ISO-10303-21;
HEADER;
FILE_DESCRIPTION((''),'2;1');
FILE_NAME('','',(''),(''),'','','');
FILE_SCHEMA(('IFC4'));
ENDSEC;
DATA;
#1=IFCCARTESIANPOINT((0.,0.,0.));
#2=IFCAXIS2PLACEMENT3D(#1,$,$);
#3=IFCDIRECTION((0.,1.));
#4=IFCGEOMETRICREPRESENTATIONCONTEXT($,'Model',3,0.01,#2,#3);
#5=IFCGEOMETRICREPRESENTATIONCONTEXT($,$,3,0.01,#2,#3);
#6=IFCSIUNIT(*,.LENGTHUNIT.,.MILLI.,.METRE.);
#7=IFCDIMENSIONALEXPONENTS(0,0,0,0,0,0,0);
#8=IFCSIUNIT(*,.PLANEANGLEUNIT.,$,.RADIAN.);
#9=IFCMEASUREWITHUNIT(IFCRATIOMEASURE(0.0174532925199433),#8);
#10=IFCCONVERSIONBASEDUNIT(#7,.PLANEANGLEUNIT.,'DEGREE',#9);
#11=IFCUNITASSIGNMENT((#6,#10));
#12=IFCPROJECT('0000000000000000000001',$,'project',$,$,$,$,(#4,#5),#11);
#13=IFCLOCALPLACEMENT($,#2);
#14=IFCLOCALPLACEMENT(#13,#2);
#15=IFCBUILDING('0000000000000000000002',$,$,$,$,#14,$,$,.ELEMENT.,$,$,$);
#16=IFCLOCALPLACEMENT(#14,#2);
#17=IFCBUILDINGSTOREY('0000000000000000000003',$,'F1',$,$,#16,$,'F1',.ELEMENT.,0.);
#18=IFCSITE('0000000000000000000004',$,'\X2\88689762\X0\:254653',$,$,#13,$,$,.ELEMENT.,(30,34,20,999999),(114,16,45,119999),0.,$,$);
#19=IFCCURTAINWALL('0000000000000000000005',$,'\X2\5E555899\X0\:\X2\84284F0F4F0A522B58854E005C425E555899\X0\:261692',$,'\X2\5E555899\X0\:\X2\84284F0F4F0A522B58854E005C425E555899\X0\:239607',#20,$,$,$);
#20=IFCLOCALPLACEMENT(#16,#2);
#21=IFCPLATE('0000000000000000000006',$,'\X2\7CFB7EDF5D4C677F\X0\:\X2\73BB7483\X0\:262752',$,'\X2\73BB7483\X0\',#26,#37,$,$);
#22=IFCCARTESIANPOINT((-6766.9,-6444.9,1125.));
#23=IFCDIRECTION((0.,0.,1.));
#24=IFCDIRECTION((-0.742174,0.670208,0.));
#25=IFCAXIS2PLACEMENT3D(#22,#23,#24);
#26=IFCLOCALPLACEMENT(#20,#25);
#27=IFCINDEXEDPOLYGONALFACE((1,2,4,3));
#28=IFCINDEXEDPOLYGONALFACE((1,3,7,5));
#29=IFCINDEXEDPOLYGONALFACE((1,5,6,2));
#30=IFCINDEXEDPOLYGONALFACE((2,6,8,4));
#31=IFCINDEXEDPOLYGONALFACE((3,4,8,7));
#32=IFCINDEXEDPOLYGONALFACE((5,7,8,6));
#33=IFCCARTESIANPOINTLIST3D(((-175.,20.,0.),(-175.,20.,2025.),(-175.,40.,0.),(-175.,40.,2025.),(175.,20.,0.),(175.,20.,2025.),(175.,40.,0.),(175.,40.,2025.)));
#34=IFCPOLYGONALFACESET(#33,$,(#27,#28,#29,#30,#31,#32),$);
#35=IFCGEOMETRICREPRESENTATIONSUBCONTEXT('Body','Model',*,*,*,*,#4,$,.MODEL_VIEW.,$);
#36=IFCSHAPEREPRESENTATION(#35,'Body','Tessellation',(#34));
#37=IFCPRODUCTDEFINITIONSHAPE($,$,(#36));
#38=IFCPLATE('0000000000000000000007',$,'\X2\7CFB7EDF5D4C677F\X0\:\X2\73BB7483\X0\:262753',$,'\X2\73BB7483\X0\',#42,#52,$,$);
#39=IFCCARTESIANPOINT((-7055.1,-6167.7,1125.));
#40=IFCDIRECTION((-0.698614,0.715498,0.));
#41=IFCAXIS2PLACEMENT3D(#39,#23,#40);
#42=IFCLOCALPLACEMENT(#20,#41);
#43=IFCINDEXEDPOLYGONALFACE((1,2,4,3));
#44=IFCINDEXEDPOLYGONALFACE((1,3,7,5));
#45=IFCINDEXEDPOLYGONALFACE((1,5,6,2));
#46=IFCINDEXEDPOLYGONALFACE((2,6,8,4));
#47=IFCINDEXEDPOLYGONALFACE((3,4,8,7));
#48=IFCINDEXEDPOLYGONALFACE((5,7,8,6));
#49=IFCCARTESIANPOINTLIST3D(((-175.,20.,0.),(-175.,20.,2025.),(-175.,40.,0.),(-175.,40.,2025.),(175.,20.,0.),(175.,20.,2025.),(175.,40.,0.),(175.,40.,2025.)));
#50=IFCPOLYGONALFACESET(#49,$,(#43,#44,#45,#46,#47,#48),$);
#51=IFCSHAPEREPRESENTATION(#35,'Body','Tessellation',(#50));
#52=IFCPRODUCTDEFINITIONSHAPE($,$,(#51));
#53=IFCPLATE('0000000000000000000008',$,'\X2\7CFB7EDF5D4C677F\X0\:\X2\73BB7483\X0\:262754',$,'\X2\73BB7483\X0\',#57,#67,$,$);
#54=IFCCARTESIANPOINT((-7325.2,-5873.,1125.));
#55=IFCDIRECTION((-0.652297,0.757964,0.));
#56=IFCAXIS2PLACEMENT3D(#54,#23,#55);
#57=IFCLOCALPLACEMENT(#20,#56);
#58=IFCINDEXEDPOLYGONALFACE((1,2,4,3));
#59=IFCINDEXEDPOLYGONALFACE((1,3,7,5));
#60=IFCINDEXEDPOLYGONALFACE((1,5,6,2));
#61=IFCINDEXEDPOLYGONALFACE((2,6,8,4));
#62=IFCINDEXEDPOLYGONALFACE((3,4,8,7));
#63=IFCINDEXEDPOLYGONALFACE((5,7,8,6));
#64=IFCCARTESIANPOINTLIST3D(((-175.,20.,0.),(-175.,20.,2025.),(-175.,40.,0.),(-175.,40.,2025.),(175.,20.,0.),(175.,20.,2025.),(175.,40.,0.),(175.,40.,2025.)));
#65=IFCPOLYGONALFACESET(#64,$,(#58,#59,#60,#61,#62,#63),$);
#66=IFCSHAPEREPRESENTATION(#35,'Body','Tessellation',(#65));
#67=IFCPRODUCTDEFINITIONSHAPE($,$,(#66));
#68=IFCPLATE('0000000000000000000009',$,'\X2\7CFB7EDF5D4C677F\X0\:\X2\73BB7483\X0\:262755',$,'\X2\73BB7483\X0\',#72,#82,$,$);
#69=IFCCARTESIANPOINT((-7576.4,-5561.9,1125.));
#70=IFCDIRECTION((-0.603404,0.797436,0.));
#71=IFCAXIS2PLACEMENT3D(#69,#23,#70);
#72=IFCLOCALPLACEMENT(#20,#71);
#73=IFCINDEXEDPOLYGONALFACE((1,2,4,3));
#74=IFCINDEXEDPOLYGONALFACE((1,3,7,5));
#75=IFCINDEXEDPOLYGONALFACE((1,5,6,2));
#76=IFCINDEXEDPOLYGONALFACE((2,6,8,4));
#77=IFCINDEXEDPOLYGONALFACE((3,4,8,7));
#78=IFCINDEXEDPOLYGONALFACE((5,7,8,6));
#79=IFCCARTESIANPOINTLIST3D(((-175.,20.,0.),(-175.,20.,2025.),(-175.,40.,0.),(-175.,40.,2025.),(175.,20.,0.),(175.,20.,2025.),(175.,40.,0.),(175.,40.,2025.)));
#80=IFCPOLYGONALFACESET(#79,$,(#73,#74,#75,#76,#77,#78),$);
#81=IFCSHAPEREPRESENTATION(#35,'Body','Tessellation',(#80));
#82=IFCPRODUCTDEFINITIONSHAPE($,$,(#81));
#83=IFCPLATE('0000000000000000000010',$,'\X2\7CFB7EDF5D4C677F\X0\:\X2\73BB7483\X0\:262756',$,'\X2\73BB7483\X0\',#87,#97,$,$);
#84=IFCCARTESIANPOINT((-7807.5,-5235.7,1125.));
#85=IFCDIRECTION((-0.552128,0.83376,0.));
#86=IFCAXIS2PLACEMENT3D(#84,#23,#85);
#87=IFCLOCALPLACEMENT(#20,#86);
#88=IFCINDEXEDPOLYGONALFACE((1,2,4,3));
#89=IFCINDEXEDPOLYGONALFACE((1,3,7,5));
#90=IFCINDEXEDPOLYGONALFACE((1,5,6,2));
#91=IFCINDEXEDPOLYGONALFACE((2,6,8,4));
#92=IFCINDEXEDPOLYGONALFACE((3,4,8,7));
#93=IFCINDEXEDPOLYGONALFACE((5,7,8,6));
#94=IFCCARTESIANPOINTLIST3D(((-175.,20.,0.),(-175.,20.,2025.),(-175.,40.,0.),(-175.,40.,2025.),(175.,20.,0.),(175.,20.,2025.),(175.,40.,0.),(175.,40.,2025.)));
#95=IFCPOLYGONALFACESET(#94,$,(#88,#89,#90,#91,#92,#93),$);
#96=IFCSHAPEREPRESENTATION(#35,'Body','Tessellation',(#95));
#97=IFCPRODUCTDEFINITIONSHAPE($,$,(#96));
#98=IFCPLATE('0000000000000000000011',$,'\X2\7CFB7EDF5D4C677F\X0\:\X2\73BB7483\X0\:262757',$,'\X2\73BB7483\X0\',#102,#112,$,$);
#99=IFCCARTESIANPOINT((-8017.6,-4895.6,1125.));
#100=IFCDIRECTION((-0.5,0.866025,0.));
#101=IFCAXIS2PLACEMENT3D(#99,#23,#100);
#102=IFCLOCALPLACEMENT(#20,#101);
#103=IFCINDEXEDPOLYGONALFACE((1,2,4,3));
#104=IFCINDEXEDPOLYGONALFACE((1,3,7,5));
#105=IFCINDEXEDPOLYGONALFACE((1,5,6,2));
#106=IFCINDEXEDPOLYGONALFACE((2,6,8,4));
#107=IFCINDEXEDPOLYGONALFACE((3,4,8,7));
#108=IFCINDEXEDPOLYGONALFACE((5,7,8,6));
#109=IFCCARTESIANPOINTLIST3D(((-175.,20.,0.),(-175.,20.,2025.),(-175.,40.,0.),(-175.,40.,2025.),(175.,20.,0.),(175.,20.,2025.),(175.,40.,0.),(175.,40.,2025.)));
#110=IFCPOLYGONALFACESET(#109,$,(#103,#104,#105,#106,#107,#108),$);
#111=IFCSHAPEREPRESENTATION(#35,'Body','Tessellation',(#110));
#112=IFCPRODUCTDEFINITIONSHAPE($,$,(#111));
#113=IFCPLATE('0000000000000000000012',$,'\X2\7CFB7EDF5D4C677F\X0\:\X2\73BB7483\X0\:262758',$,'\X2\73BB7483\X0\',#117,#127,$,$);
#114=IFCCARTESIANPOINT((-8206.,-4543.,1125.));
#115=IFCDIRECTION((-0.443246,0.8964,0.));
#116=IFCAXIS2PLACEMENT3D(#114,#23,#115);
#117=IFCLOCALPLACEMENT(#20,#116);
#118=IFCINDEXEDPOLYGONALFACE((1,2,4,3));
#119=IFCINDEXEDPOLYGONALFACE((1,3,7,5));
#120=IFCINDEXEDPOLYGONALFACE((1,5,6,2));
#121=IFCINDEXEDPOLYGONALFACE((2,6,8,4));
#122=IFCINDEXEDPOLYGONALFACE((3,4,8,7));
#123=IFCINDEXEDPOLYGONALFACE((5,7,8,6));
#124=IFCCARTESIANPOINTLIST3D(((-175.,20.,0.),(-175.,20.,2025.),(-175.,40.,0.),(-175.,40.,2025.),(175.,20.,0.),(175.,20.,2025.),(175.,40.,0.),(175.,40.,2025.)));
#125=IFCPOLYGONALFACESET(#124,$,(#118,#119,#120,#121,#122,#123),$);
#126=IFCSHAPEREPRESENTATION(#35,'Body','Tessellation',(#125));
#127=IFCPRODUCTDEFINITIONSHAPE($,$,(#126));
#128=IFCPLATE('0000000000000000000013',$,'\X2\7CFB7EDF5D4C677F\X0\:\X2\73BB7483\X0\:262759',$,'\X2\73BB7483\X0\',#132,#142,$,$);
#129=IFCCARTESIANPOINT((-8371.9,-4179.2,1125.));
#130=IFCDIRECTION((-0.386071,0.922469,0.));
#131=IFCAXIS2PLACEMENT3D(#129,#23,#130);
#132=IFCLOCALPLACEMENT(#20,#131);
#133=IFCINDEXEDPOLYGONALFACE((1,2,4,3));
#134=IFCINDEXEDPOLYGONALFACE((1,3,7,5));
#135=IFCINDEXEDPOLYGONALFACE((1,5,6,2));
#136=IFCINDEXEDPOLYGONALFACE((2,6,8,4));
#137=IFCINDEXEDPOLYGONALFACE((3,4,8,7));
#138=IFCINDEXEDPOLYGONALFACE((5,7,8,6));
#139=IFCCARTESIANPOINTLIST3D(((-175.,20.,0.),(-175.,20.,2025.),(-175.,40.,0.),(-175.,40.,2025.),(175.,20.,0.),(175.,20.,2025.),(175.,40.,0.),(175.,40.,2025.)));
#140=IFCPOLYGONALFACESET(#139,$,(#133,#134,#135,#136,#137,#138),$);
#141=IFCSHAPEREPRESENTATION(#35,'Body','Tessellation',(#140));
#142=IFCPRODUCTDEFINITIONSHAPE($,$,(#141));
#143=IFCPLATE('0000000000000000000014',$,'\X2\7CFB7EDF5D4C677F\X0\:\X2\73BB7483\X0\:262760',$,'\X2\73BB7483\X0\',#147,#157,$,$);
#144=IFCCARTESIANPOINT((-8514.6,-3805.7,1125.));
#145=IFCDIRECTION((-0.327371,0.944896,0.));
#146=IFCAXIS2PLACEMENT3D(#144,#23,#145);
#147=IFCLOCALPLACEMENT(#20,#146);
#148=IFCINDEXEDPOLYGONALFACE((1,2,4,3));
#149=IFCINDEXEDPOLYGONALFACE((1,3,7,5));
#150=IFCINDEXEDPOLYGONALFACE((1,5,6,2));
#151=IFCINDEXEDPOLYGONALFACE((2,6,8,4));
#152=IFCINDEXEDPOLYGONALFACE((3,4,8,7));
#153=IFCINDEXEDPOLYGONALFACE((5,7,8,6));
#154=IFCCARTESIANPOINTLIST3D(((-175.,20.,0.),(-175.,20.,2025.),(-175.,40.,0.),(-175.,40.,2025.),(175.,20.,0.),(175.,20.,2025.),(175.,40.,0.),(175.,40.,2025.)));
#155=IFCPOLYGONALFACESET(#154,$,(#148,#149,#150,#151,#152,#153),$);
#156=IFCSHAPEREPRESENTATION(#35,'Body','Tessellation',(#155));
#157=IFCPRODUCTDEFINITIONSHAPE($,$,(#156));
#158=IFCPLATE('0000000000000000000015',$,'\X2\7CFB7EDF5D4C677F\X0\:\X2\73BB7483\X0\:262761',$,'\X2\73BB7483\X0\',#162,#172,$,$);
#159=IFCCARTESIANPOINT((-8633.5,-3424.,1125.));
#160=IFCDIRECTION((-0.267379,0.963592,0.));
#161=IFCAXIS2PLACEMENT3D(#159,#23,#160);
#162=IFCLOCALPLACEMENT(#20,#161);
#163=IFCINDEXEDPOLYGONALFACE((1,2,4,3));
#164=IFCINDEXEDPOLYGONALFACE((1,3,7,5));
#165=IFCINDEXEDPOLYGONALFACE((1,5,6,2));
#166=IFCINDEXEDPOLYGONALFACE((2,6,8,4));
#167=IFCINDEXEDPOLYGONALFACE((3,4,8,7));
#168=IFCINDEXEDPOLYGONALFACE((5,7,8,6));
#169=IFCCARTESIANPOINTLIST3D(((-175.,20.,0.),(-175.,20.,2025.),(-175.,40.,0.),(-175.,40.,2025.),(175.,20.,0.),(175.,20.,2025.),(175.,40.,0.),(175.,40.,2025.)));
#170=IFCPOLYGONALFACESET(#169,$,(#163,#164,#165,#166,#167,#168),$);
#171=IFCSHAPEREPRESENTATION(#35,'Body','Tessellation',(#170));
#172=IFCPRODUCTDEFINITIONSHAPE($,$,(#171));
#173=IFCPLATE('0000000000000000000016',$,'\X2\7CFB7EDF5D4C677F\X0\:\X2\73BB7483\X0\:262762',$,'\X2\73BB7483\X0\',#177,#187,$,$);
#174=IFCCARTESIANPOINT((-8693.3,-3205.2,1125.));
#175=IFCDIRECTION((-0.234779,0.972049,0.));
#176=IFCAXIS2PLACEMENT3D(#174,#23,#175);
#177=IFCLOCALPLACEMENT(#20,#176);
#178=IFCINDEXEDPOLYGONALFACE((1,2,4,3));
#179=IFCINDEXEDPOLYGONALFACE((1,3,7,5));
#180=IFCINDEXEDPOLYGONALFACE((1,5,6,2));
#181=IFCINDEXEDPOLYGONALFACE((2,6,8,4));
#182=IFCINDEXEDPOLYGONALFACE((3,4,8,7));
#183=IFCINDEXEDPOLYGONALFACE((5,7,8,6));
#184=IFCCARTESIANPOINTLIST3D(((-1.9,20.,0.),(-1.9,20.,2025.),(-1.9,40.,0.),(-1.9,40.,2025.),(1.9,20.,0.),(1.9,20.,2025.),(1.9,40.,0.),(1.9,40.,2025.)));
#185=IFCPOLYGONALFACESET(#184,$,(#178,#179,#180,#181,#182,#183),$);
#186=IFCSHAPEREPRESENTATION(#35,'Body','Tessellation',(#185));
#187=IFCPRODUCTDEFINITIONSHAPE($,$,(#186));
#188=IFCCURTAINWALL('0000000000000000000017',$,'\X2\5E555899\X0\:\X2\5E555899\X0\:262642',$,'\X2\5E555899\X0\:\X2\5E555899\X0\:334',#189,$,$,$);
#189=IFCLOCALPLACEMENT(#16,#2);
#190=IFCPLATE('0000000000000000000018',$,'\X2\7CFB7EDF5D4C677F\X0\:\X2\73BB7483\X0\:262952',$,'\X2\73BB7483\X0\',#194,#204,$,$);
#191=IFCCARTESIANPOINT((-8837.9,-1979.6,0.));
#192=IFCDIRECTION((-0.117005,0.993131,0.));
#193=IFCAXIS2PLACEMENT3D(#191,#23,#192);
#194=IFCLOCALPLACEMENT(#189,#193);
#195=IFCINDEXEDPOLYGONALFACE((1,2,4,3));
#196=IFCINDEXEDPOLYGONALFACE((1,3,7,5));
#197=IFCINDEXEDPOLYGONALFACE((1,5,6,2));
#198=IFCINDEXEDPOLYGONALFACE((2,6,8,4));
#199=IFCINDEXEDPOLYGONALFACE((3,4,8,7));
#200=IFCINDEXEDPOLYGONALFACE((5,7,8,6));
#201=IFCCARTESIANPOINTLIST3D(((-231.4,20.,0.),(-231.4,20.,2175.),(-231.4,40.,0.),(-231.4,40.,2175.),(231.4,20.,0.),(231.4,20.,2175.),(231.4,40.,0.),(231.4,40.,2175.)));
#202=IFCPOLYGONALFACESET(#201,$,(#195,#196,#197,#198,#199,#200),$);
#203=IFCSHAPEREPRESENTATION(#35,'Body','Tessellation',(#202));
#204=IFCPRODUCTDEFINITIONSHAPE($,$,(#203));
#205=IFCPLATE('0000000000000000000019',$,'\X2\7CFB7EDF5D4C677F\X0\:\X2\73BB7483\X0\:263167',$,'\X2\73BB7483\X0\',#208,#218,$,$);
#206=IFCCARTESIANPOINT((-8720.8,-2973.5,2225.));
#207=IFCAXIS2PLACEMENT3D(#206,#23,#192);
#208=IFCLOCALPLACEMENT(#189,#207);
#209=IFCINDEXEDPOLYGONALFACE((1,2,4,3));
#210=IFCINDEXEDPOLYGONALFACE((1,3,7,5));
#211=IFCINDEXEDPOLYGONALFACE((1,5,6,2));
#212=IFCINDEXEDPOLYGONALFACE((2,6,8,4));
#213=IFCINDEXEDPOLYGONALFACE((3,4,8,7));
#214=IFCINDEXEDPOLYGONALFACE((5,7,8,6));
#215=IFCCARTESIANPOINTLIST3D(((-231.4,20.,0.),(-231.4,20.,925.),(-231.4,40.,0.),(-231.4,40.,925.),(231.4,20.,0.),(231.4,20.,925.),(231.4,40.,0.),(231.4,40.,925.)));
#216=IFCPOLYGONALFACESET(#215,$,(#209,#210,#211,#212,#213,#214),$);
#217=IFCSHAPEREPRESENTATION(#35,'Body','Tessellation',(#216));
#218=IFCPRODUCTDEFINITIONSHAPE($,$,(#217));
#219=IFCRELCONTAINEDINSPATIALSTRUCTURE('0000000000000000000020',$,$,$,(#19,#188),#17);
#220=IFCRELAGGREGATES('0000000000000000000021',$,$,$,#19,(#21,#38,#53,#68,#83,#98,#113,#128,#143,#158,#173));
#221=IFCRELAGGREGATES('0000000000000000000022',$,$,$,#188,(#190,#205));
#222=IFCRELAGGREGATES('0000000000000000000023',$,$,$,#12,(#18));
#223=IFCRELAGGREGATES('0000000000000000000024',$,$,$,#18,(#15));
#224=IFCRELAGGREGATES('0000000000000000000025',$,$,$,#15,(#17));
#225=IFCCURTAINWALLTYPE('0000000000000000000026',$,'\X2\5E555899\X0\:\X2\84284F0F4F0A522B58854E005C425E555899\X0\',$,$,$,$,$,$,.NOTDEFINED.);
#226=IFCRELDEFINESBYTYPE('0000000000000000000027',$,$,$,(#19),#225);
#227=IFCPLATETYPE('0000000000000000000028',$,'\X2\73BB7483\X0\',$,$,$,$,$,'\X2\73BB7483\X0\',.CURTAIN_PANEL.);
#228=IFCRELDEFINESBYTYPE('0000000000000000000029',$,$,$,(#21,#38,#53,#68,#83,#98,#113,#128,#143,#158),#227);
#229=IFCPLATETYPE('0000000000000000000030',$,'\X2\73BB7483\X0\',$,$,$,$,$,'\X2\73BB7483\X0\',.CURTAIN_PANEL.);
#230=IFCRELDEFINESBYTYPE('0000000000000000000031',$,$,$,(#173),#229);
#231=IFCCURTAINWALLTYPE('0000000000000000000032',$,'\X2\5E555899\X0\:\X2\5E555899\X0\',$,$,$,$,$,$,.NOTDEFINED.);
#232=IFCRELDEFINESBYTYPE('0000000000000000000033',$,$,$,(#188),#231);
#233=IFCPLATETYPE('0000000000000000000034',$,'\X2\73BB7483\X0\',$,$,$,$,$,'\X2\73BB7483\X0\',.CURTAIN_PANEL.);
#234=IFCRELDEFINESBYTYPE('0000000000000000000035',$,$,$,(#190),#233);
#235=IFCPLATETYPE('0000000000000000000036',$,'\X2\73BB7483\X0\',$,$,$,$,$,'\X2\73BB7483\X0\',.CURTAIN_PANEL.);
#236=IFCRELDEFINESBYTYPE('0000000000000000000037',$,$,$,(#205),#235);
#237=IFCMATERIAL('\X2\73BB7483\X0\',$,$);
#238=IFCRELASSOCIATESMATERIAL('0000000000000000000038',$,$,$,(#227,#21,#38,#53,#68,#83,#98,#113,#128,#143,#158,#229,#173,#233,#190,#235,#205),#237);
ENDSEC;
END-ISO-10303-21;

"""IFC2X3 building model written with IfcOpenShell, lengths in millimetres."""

from ifc_helpers import new_model, entity, si_unit, converted_unit, direction, frame, frame_2d, origin, place, context, subcontext, project, spatial, rectangle, extrude, source, transform, mapped, material, type_object, type_shapes, element, aggregate, save


model = new_model("IFC2X3")

# Units and contexts
model_context = context("Model", 3, precision=0.01, world=origin(), true_north=direction((0.0, 1.0)))
context_of_model = context(None, 3, precision=0.01, world=origin(), true_north=direction((0.0, 1.0)))
body_context = subcontext(model_context, "Body", "Model", "MODEL_VIEW")
ifc_project = project(units=[si_unit("LENGTHUNIT", "METRE", prefix="MILLI"), converted_unit("PLANEANGLEUNIT", "DEGREE", entity("IfcRatioMeasure", 0.0174532925199433), si_unit("PLANEANGLEUNIT", "RADIAN"), dimensions=[0, 0, 0, 0, 0, 0, 0])], contexts=[model_context, context_of_model])

# Site, building, storey
site_placement = place(None, origin())
site = spatial("IfcSite", under=ifc_project, at=site_placement, Name="表面:254653", CompositionType="ELEMENT", RefLatitude=(30, 34, 20, 999999), RefLongitude=(114, 16, 45, 119999), RefElevation=0.0)
building_placement = place(site_placement, origin())
building = spatial("IfcBuilding", under=site, at=building_placement, CompositionType="ELEMENT")
storey_placement = place(building_placement, origin())
storey = spatial("IfcBuildingStorey", under=building, at=storey_placement, Name="F1", LongName="F1", CompositionType="ELEMENT", Elevation=0.0)

# Curtain walls, plates
curtain_wall_type_1 = type_object("IfcCurtainWallType", Name="幕墙:萨伏伊别墅一层幕墙", PredefinedType="NOTDEFINED")
curtain_wall_1_placement = place(storey_placement, origin())
curtain_wall_1 = element("IfcCurtainWall", 1, at=curtain_wall_1_placement, inside=storey, type_object=curtain_wall_type_1, Name="幕墙:萨伏伊别墅一层幕墙:261692", ObjectType="幕墙:萨伏伊别墅一层幕墙:239607")
ifc_material_1 = material(Name="玻璃")
plate_type_1 = type_object("IfcPlateType", Name="玻璃", ElementType="玻璃", PredefinedType="CURTAIN_PANEL", material=ifc_material_1)
shared_shape_1 = source(origin(), body_context, "Body", "SweptSolid", [
    extrude(rectangle(XDim=20.0, YDim=350.0, at=frame_2d((0.0, 0.0), x_axis=(1.0, 0.0))), frame((0.0, 30.0, 0.0), z_axis=(0.0, 0.0, 1.0), x_axis=(0.0, 1.0, 0.0)), (0.0, 0.0, 1.0), 2025.0),
])
type_shapes(plate_type_1, [shared_shape_1])
plate_1_placement = place(curtain_wall_1_placement, frame((-6766.9, -6444.9, 1125.0), z_axis=(0.0, 0.0, 1.0), x_axis=(-0.742174, 0.670208, 0.0)))
plate_1 = element("IfcPlate", 2, at=plate_1_placement, type_object=plate_type_1, material=ifc_material_1, Name="系统嵌板:玻璃:262752", ObjectType="玻璃", context=body_context, shape_type="MappedRepresentation", body=[
    mapped(shared_shape_1, transform((0.0, 0.0, 0.0), scale=1.0)),
])
plate_2_placement = place(curtain_wall_1_placement, frame((-7055.1, -6167.7, 1125.0), z_axis=(0.0, 0.0, 1.0), x_axis=(-0.698614, 0.715498, 0.0)))
plate_2 = element("IfcPlate", 3, at=plate_2_placement, type_object=plate_type_1, material=ifc_material_1, Name="系统嵌板:玻璃:262753", ObjectType="玻璃", context=body_context, shape_type="MappedRepresentation", body=[
    mapped(shared_shape_1, transform((0.0, 0.0, 0.0), scale=1.0)),
])
plate_3_placement = place(curtain_wall_1_placement, frame((-7325.2, -5873.0, 1125.0), z_axis=(0.0, 0.0, 1.0), x_axis=(-0.652297, 0.757964, 0.0)))
plate_3 = element("IfcPlate", 4, at=plate_3_placement, type_object=plate_type_1, material=ifc_material_1, Name="系统嵌板:玻璃:262754", ObjectType="玻璃", context=body_context, shape_type="MappedRepresentation", body=[
    mapped(shared_shape_1, transform((0.0, 0.0, 0.0), scale=1.0)),
])
plate_4_placement = place(curtain_wall_1_placement, frame((-7576.4, -5561.9, 1125.0), z_axis=(0.0, 0.0, 1.0), x_axis=(-0.603404, 0.797436, 0.0)))
plate_4 = element("IfcPlate", 5, at=plate_4_placement, type_object=plate_type_1, material=ifc_material_1, Name="系统嵌板:玻璃:262755", ObjectType="玻璃", context=body_context, shape_type="MappedRepresentation", body=[
    mapped(shared_shape_1, transform((0.0, 0.0, 0.0), scale=1.0)),
])
plate_5_placement = place(curtain_wall_1_placement, frame((-7807.5, -5235.7, 1125.0), z_axis=(0.0, 0.0, 1.0), x_axis=(-0.552128, 0.83376, 0.0)))
plate_5 = element("IfcPlate", 6, at=plate_5_placement, type_object=plate_type_1, material=ifc_material_1, Name="系统嵌板:玻璃:262756", ObjectType="玻璃", context=body_context, shape_type="MappedRepresentation", body=[
    mapped(shared_shape_1, transform((0.0, 0.0, 0.0), scale=1.0)),
])
plate_6_placement = place(curtain_wall_1_placement, frame((-8017.6, -4895.6, 1125.0), z_axis=(0.0, 0.0, 1.0), x_axis=(-0.5, 0.866025, 0.0)))
plate_6 = element("IfcPlate", 7, at=plate_6_placement, type_object=plate_type_1, material=ifc_material_1, Name="系统嵌板:玻璃:262757", ObjectType="玻璃", context=body_context, shape_type="MappedRepresentation", body=[
    mapped(shared_shape_1, transform((0.0, 0.0, 0.0), scale=1.0)),
])
plate_7_placement = place(curtain_wall_1_placement, frame((-8206.0, -4543.0, 1125.0), z_axis=(0.0, 0.0, 1.0), x_axis=(-0.443246, 0.8964, 0.0)))
plate_7 = element("IfcPlate", 8, at=plate_7_placement, type_object=plate_type_1, material=ifc_material_1, Name="系统嵌板:玻璃:262758", ObjectType="玻璃", context=body_context, shape_type="MappedRepresentation", body=[
    mapped(shared_shape_1, transform((0.0, 0.0, 0.0), scale=1.0)),
])
plate_8_placement = place(curtain_wall_1_placement, frame((-8371.9, -4179.2, 1125.0), z_axis=(0.0, 0.0, 1.0), x_axis=(-0.386071, 0.922469, 0.0)))
plate_8 = element("IfcPlate", 9, at=plate_8_placement, type_object=plate_type_1, material=ifc_material_1, Name="系统嵌板:玻璃:262759", ObjectType="玻璃", context=body_context, shape_type="MappedRepresentation", body=[
    mapped(shared_shape_1, transform((0.0, 0.0, 0.0), scale=1.0)),
])
plate_9_placement = place(curtain_wall_1_placement, frame((-8514.6, -3805.7, 1125.0), z_axis=(0.0, 0.0, 1.0), x_axis=(-0.327371, 0.944896, 0.0)))
plate_9 = element("IfcPlate", 10, at=plate_9_placement, type_object=plate_type_1, material=ifc_material_1, Name="系统嵌板:玻璃:262760", ObjectType="玻璃", context=body_context, shape_type="MappedRepresentation", body=[
    mapped(shared_shape_1, transform((0.0, 0.0, 0.0), scale=1.0)),
])
plate_10_placement = place(curtain_wall_1_placement, frame((-8633.5, -3424.0, 1125.0), z_axis=(0.0, 0.0, 1.0), x_axis=(-0.267379, 0.963592, 0.0)))
plate_10 = element("IfcPlate", 11, at=plate_10_placement, type_object=plate_type_1, material=ifc_material_1, Name="系统嵌板:玻璃:262761", ObjectType="玻璃", context=body_context, shape_type="MappedRepresentation", body=[
    mapped(shared_shape_1, transform((0.0, 0.0, 0.0), scale=1.0)),
])
plate_type_2 = type_object("IfcPlateType", Name="玻璃", ElementType="玻璃", PredefinedType="CURTAIN_PANEL", material=ifc_material_1)
shared_shape_2 = source(origin(), body_context, "Body", "SweptSolid", [
    extrude(rectangle(XDim=20.0, YDim=3.7, at=frame_2d((0.0, 0.0), x_axis=(1.0, 0.0))), frame((0.0, 30.0, 0.0), z_axis=(0.0, 0.0, 1.0), x_axis=(0.0, 1.0, 0.0)), (0.0, 0.0, 1.0), 2025.0),
])
type_shapes(plate_type_2, [shared_shape_2])
plate_11_placement = place(curtain_wall_1_placement, frame((-8693.3, -3205.2, 1125.0), z_axis=(0.0, 0.0, 1.0), x_axis=(-0.234779, 0.972049, 0.0)))
plate_11 = element("IfcPlate", 12, at=plate_11_placement, type_object=plate_type_2, material=ifc_material_1, Name="系统嵌板:玻璃:262762", ObjectType="玻璃", context=body_context, shape_type="MappedRepresentation", body=[
    mapped(shared_shape_2, transform((0.0, 0.0, 0.0), scale=1.0)),
])
aggregate(curtain_wall_1, [plate_1, plate_2, plate_3, plate_4, plate_5, plate_6, plate_7, plate_8, plate_9, plate_10, plate_11])
curtain_wall_type_2 = type_object("IfcCurtainWallType", Name="幕墙:幕墙", PredefinedType="NOTDEFINED")
curtain_wall_2_placement = place(storey_placement, origin())
curtain_wall_2 = element("IfcCurtainWall", 13, at=curtain_wall_2_placement, inside=storey, type_object=curtain_wall_type_2, Name="幕墙:幕墙:262642", ObjectType="幕墙:幕墙:334")
plate_type_3 = type_object("IfcPlateType", Name="玻璃", ElementType="玻璃", PredefinedType="CURTAIN_PANEL", material=ifc_material_1)
shared_shape_3 = source(origin(), body_context, "Body", "SweptSolid", [
    extrude(rectangle(XDim=20.0, YDim=462.9, at=frame_2d((0.0, 0.0), x_axis=(1.0, 0.0))), frame((0.0, 30.0, 0.0), z_axis=(0.0, 0.0, 1.0), x_axis=(0.0, 1.0, 0.0)), (0.0, 0.0, 1.0), 2175.0),
])
type_shapes(plate_type_3, [shared_shape_3])
plate_12_placement = place(curtain_wall_2_placement, frame((-8837.9, -1979.6, 0.0), z_axis=(0.0, 0.0, 1.0), x_axis=(-0.117005, 0.993131, 0.0)))
plate_12 = element("IfcPlate", 14, at=plate_12_placement, type_object=plate_type_3, material=ifc_material_1, Name="系统嵌板:玻璃:262952", ObjectType="玻璃", context=body_context, shape_type="MappedRepresentation", body=[
    mapped(shared_shape_3, transform((0.0, 0.0, 0.0), scale=1.0)),
])
plate_type_4 = type_object("IfcPlateType", Name="玻璃", ElementType="玻璃", PredefinedType="CURTAIN_PANEL", material=ifc_material_1)
shared_shape_4 = source(origin(), body_context, "Body", "SweptSolid", [
    extrude(rectangle(XDim=20.0, YDim=462.9, at=frame_2d((0.0, 0.0), x_axis=(1.0, 0.0))), frame((0.0, 30.0, 0.0), z_axis=(0.0, 0.0, 1.0), x_axis=(0.0, 1.0, 0.0)), (0.0, 0.0, 1.0), 925.0),
])
type_shapes(plate_type_4, [shared_shape_4])
plate_13_placement = place(curtain_wall_2_placement, frame((-8720.8, -2973.5, 2225.0), z_axis=(0.0, 0.0, 1.0), x_axis=(-0.117005, 0.993131, 0.0)))
plate_13 = element("IfcPlate", 15, at=plate_13_placement, type_object=plate_type_4, material=ifc_material_1, Name="系统嵌板:玻璃:263167", ObjectType="玻璃", context=body_context, shape_type="MappedRepresentation", body=[
    mapped(shared_shape_4, transform((0.0, 0.0, 0.0), scale=1.0)),
])

aggregate(curtain_wall_2, [plate_12, plate_13])

save(model, "model.ifc")
